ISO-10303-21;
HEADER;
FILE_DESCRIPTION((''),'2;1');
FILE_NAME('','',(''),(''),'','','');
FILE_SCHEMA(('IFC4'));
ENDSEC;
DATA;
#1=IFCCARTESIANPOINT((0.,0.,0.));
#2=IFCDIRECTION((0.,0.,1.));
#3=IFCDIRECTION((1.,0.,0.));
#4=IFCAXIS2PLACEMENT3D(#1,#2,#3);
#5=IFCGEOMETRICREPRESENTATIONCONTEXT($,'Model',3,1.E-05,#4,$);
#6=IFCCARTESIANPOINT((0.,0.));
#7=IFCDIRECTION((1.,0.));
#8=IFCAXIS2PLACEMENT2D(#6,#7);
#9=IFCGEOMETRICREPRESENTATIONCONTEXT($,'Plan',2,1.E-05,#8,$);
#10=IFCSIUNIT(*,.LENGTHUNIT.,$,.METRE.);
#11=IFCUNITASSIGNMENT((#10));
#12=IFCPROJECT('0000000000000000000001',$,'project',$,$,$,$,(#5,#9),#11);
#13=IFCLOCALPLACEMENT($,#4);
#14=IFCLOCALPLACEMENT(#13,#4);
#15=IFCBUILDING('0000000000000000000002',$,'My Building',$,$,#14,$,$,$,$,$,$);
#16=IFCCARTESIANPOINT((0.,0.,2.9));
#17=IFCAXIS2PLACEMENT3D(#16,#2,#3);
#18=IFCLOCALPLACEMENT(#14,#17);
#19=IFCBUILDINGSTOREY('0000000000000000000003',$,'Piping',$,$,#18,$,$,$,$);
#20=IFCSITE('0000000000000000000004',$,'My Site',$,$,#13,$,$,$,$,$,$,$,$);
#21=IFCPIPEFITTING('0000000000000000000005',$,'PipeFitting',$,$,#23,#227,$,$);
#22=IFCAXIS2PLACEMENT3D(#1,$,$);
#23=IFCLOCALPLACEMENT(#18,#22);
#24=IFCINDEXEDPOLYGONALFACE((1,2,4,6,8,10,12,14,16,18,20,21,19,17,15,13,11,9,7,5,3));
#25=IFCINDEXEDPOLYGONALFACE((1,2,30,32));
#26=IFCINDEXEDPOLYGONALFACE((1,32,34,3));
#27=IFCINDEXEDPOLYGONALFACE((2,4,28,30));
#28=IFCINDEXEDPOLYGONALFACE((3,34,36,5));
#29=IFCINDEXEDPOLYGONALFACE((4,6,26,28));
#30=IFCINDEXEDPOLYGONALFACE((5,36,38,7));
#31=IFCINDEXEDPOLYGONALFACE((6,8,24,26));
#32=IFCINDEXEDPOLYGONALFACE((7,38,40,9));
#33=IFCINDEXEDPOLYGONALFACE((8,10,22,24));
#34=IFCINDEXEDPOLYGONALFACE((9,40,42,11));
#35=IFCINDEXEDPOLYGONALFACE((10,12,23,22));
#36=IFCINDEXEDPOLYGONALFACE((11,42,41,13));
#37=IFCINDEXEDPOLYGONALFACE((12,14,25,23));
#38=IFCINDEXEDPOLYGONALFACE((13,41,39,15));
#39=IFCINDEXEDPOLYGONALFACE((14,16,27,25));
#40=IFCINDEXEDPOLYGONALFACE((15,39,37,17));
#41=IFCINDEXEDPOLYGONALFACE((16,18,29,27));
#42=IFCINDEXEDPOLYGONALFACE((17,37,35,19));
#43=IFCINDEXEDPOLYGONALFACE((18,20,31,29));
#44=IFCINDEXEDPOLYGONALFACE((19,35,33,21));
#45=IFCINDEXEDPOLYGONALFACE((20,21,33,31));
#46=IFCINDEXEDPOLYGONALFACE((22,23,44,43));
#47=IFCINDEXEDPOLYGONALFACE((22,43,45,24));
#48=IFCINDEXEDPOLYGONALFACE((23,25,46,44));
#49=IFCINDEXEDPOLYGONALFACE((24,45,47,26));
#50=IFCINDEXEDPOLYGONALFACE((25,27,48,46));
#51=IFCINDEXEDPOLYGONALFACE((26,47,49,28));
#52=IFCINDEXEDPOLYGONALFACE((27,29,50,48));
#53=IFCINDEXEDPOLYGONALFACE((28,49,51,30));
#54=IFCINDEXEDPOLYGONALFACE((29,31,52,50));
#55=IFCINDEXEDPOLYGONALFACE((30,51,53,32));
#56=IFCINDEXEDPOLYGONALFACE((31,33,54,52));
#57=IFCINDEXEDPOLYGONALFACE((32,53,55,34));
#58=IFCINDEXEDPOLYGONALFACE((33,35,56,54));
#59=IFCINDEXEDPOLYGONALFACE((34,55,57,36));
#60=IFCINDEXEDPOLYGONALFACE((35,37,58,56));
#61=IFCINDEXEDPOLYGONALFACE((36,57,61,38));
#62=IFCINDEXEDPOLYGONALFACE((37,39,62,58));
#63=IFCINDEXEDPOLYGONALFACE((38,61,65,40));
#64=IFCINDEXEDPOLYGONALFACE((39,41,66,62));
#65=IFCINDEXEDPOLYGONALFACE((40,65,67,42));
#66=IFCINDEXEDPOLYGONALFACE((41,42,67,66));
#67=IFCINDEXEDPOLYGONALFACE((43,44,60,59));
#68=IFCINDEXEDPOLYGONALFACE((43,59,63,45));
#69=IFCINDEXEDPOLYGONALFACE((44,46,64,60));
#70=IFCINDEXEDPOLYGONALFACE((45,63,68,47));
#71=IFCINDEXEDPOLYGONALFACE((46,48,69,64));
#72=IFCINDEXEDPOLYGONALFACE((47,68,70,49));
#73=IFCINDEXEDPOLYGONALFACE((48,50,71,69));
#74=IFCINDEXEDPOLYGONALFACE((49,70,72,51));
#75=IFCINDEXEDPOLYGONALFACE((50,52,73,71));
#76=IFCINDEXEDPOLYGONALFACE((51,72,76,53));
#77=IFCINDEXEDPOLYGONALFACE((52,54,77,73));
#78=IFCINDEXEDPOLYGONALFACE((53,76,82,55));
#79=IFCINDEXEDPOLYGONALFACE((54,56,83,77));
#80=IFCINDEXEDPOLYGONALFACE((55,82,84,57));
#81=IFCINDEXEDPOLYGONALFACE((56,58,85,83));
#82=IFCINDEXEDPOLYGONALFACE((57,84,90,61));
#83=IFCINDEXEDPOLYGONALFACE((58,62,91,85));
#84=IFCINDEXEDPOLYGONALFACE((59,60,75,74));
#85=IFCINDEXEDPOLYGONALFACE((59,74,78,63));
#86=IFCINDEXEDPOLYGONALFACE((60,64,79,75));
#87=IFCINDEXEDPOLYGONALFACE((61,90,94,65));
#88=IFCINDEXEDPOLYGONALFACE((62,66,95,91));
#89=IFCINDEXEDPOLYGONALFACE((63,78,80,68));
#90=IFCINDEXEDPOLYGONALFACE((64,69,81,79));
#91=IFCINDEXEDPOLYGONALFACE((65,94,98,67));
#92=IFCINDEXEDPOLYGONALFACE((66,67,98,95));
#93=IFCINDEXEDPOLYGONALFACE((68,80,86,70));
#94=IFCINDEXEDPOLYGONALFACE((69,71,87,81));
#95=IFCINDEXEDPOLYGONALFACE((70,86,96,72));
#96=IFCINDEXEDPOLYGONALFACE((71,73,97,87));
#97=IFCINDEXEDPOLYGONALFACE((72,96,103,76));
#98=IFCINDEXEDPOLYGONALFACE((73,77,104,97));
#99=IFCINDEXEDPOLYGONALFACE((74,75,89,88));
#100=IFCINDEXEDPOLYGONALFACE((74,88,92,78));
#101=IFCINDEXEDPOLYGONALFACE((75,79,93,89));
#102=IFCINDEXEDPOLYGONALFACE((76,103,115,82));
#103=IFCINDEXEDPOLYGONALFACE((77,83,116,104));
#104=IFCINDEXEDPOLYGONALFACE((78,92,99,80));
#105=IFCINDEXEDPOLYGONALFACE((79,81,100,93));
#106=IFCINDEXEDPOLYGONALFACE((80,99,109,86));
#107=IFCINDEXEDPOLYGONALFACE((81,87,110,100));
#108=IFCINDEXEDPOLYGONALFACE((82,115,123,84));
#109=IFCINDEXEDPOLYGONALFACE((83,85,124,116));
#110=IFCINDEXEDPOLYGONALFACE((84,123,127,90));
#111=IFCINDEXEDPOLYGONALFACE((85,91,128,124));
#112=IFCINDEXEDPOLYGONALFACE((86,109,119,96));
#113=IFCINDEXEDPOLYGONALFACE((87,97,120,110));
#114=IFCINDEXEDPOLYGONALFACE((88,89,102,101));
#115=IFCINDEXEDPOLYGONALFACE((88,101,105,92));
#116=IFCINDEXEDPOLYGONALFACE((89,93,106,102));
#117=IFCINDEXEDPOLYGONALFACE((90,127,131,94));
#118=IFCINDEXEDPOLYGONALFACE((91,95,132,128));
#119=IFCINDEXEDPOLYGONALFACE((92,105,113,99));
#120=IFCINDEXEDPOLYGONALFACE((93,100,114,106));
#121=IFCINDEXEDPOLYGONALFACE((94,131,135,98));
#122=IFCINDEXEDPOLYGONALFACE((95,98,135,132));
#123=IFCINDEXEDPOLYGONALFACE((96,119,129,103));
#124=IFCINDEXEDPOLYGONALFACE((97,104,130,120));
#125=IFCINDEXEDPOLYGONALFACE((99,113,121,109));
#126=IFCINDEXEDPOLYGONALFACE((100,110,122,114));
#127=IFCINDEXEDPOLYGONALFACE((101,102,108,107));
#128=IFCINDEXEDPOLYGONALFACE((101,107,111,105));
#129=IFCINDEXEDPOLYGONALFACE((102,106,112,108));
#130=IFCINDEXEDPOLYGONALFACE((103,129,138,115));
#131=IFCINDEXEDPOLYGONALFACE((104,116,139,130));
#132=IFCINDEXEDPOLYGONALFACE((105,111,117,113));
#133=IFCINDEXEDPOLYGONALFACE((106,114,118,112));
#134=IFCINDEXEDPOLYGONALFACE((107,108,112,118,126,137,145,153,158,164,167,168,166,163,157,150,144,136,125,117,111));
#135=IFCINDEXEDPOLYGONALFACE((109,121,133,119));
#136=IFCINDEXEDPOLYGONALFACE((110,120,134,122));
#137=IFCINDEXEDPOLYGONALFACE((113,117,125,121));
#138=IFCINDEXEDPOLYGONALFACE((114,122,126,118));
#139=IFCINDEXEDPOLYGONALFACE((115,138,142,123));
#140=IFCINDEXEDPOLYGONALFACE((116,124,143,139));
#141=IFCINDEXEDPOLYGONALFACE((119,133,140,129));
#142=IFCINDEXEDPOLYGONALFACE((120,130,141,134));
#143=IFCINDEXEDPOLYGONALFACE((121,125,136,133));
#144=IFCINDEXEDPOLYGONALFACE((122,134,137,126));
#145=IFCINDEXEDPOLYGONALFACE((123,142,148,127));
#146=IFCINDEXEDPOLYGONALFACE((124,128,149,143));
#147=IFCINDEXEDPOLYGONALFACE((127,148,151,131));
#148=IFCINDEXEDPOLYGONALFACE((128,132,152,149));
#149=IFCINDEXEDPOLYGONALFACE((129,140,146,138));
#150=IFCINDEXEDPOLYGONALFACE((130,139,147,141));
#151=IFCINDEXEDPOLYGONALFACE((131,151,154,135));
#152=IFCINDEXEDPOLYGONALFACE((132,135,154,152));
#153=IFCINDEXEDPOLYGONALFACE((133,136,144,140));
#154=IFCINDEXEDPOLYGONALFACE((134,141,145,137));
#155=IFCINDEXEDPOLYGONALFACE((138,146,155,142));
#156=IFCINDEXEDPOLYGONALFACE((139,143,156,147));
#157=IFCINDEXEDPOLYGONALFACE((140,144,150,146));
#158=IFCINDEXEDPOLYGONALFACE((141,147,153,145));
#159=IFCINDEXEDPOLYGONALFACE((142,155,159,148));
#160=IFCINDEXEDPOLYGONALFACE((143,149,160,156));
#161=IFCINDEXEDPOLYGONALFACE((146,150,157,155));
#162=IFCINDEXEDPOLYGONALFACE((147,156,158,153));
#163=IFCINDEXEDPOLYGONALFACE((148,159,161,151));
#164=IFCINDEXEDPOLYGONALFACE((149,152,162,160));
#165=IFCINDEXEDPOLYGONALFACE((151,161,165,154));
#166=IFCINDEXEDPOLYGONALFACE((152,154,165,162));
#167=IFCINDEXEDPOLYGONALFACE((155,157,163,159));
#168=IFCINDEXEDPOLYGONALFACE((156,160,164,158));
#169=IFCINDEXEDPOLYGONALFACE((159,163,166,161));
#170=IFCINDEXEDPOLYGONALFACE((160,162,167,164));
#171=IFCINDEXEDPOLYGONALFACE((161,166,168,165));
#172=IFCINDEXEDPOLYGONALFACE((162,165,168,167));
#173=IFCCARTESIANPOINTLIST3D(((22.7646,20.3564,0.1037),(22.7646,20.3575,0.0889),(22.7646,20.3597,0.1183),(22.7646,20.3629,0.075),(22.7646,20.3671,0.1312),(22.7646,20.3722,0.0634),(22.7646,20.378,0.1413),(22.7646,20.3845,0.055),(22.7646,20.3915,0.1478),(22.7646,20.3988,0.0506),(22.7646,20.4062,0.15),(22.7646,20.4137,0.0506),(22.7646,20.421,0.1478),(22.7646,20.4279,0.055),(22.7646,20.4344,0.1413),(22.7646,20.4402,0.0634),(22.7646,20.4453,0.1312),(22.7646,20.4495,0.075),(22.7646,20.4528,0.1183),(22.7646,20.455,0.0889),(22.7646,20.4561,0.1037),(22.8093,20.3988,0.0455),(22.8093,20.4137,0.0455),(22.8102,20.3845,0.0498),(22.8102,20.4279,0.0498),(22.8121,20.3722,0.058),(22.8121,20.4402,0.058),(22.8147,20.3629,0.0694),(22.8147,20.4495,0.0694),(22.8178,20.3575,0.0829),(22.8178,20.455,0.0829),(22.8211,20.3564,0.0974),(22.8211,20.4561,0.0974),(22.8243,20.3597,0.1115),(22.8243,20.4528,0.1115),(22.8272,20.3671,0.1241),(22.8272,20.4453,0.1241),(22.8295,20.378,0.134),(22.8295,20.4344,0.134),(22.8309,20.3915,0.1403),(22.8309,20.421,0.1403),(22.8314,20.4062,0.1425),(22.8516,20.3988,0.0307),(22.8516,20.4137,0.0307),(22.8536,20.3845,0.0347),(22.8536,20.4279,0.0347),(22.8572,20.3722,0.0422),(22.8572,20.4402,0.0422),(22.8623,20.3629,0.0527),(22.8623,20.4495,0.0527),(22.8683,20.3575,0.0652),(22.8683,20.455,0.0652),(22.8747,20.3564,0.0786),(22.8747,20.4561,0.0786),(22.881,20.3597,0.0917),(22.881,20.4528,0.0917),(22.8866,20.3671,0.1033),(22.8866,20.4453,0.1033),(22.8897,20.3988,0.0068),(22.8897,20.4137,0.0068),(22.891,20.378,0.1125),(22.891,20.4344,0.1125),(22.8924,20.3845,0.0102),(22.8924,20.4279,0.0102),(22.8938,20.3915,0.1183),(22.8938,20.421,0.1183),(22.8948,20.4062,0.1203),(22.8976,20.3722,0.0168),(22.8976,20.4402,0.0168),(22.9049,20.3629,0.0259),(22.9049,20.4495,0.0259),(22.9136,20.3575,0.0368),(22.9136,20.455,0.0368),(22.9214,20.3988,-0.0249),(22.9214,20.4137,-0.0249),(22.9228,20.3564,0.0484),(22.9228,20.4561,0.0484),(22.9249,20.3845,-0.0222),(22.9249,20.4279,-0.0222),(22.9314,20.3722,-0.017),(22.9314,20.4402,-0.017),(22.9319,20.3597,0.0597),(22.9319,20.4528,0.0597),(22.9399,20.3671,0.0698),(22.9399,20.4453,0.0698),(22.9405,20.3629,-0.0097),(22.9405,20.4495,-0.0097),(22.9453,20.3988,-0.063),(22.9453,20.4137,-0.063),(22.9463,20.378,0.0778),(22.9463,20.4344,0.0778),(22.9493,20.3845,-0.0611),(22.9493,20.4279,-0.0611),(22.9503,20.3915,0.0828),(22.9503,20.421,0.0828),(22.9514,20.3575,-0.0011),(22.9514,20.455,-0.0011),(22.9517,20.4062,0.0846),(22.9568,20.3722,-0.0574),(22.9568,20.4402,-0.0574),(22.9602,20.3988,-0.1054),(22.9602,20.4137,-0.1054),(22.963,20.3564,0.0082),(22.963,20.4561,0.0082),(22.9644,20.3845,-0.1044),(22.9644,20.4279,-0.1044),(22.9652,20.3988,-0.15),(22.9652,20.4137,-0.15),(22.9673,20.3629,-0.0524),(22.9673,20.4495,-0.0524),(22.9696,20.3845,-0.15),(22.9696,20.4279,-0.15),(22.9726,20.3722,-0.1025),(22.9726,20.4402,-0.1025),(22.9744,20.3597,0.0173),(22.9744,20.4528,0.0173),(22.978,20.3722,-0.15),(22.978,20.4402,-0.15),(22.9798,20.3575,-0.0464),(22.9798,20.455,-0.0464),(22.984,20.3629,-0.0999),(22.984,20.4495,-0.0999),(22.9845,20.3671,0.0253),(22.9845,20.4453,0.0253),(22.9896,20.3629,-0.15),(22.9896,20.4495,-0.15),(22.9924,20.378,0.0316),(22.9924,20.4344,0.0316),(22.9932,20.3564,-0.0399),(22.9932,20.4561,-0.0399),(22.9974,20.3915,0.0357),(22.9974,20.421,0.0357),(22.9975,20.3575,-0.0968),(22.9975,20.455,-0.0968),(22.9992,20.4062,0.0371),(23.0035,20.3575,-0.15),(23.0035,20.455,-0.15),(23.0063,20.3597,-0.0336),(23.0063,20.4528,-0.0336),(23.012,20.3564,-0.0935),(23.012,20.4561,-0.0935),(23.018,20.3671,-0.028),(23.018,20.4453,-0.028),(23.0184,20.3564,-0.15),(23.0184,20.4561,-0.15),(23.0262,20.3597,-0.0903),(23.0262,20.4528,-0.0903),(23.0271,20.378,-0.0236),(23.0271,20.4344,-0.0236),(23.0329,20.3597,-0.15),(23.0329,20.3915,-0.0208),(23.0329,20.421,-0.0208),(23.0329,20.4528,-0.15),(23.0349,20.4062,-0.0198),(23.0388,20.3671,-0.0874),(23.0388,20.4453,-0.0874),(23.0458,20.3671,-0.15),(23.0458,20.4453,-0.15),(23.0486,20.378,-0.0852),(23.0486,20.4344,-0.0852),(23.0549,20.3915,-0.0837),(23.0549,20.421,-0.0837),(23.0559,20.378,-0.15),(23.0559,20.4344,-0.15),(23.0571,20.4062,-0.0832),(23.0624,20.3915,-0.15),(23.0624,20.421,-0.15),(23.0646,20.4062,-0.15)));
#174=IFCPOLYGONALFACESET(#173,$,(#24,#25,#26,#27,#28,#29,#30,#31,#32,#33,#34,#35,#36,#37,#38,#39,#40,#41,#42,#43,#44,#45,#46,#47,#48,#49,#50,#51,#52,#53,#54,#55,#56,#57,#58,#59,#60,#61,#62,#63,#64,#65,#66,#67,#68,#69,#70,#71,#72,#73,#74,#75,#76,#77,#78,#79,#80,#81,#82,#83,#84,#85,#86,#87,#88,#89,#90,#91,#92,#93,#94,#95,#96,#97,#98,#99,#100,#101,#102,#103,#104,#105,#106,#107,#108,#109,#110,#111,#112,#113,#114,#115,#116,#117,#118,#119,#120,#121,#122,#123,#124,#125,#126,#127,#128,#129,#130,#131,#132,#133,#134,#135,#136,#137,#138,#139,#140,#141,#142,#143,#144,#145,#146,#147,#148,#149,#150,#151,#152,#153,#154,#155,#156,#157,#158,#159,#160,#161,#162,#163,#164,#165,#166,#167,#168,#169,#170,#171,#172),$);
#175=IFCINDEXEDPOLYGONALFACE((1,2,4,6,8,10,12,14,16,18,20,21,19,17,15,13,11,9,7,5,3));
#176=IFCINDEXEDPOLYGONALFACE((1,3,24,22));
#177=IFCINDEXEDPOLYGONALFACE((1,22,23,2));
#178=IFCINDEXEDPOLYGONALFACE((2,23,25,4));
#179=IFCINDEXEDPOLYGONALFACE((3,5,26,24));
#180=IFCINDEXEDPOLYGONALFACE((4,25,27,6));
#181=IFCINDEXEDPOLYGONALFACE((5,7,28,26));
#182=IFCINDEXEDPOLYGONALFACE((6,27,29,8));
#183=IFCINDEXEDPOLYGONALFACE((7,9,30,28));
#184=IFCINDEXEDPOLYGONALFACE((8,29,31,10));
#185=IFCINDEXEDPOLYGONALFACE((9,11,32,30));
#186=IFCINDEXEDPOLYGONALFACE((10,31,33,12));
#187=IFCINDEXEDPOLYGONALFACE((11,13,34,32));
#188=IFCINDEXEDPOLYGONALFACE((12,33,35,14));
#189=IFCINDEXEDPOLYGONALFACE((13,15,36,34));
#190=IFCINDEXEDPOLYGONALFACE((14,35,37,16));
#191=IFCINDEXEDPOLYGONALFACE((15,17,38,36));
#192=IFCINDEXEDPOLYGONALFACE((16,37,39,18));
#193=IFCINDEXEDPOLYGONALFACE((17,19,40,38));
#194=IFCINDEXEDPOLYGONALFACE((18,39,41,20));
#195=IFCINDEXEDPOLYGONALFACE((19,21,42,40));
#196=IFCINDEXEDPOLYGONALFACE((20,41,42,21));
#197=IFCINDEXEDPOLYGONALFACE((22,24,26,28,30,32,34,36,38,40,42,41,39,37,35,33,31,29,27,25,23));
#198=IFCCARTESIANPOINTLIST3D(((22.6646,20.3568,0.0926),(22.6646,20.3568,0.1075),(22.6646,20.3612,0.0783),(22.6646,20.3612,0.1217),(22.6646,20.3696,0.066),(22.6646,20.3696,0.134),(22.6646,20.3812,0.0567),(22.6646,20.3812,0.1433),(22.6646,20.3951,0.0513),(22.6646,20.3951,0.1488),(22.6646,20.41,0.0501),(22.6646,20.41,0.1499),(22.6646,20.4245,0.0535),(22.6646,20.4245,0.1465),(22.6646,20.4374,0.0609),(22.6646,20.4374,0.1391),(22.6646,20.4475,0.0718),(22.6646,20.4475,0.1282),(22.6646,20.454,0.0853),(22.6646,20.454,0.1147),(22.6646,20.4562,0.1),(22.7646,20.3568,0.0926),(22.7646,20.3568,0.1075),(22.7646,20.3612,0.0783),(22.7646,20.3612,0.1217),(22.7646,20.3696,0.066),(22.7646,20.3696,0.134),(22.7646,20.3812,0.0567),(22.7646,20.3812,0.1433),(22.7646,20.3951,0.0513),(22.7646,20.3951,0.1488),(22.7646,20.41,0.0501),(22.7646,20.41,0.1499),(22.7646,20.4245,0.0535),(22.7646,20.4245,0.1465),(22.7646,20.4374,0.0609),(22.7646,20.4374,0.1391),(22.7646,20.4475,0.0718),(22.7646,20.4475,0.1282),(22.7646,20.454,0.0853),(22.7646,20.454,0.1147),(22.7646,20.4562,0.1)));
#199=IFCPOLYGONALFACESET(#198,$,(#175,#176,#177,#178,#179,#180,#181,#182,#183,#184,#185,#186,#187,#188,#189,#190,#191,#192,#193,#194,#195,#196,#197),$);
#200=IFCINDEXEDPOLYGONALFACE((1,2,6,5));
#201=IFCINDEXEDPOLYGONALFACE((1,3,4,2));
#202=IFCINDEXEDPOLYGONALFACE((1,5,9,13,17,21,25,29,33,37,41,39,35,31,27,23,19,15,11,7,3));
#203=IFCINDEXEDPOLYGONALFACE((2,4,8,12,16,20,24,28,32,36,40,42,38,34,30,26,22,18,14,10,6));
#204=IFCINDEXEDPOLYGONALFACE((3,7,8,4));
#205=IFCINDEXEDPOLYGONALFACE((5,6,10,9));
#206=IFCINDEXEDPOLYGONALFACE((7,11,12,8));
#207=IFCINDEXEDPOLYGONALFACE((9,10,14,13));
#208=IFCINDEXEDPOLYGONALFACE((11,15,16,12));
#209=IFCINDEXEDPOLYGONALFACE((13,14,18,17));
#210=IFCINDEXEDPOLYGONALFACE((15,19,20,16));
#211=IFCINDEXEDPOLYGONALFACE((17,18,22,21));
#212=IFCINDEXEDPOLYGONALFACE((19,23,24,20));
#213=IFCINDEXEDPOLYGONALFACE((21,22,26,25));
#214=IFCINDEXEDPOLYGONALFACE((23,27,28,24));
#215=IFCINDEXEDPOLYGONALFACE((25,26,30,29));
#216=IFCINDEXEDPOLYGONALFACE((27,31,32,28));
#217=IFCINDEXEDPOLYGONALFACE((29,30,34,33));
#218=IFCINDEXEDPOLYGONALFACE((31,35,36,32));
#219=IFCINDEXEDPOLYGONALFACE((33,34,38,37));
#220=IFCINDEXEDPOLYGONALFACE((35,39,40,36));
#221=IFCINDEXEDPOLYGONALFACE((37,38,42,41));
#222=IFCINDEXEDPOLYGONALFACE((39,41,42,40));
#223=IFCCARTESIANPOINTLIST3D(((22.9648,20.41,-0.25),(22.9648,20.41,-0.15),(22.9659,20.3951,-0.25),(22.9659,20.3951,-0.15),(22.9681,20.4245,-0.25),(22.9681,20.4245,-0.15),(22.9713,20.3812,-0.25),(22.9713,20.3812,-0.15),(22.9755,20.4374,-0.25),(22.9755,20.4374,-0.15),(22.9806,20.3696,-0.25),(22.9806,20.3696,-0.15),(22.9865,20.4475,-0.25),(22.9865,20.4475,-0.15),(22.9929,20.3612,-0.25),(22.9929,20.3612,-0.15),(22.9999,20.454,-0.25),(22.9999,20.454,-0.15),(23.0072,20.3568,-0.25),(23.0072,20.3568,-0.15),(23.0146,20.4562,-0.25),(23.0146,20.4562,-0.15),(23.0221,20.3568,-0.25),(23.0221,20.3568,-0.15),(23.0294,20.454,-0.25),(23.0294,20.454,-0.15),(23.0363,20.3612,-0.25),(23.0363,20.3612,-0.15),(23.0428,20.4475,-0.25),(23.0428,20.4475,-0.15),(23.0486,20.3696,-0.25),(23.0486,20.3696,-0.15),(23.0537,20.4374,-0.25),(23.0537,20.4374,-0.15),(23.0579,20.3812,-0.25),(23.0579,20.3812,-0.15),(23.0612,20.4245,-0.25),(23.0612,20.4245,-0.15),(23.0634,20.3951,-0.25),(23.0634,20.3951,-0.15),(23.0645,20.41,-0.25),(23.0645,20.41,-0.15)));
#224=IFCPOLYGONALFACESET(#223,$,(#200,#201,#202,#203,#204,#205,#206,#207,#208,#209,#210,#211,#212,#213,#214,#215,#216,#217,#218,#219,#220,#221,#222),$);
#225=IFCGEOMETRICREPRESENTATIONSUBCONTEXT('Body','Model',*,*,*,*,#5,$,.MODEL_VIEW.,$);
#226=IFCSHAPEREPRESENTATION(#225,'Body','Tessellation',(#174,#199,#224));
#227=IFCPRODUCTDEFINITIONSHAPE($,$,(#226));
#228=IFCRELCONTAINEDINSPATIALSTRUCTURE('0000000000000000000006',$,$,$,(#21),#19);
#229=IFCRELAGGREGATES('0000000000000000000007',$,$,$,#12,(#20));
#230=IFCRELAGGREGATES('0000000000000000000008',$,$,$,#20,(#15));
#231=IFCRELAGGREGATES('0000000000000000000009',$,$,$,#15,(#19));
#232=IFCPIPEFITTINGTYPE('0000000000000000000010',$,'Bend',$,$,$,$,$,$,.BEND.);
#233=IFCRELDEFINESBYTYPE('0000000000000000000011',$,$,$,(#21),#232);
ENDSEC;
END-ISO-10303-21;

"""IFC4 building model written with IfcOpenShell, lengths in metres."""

from ifc_helpers import new_model, entity, si_unit, frame, origin_with_axes, origin_2d_with_axis, place, context, subcontext, project, spatial, circle, extrude, source, transform, mapped, type_object, type_shapes, element, save


model = new_model("IFC4")

# Units and contexts
model_context = context("Model", 3, precision=1e-05, world=origin_with_axes())
plan_context = context("Plan", 2, precision=1e-05, world=origin_2d_with_axis())
body_context = subcontext(model_context, "Body", "Model", "MODEL_VIEW")
ifc_project = project(units=[si_unit("LENGTHUNIT", "METRE")], contexts=[model_context, plan_context])

# Site, building, storey
site_placement = place(None, origin_with_axes())
site = spatial("IfcSite", under=ifc_project, at=site_placement, Name="My Site")
building_placement = place(site_placement, origin_with_axes())
building = spatial("IfcBuilding", under=site, at=building_placement, Name="My Building")
storey_placement = place(building_placement, frame((0.0, 0.0, 2.9), z_axis=(0.0, 0.0, 1.0), x_axis=(1.0, 0.0, 0.0)))
storey = spatial("IfcBuildingStorey", under=building, at=storey_placement, Name="Piping")

# Pipe fitting
pipe_fitting_type = type_object("IfcPipeFittingType", Name="Bend", PredefinedType="BEND")
shared_shape = source(origin_with_axes(), body_context, "Body", "SolidModel", [
    entity("IfcSweptDiskSolid", entity("IfcIndexedPolyCurve", entity("IfcCartesianPointList3D", [[0.0, 0.0, 0.1], [0.0, -0.0732, 0.2768], [0.0, -0.25, 0.35]]), [entity("IfcArcIndex", [1, 2, 3])]), 0.05),
    extrude(circle(Radius=0.05), origin_with_axes(), (0.0, 0.0, 1.0), 0.1),
    extrude(circle(Radius=0.05), frame((0.0, -0.25, 0.35), z_axis=(0.0, -1.0, -0.000001), x_axis=(1.0, 0.0, 0.0)), (0.0, 0.0, 1.0), 0.1),
])
type_shapes(pipe_fitting_type, [shared_shape])
for number, where, z_axis, x_axis, name in (
    (1, (22.6646, 20.4062, 0.1), (1.0, -0.000001, 0.000001), (0.000001, 1.0, 0.0), "PipeFitting"),
):
    element("IfcPipeFitting", number, at=place(storey_placement, frame(where, z_axis=z_axis, x_axis=x_axis)), inside=storey, type_object=pipe_fitting_type, Name=name, context=body_context, shape_type="MappedRepresentation", body=[
        mapped(shared_shape, transform((0.0, 0.0, 0.0), x_axis=(1.0, 0.0, 0.0), y_axis=(0.0, 1.0, 0.0), z_axis=(0.0, 0.0, 1.0), scale=1.0)),
    ])

save(model, "model.ifc")
